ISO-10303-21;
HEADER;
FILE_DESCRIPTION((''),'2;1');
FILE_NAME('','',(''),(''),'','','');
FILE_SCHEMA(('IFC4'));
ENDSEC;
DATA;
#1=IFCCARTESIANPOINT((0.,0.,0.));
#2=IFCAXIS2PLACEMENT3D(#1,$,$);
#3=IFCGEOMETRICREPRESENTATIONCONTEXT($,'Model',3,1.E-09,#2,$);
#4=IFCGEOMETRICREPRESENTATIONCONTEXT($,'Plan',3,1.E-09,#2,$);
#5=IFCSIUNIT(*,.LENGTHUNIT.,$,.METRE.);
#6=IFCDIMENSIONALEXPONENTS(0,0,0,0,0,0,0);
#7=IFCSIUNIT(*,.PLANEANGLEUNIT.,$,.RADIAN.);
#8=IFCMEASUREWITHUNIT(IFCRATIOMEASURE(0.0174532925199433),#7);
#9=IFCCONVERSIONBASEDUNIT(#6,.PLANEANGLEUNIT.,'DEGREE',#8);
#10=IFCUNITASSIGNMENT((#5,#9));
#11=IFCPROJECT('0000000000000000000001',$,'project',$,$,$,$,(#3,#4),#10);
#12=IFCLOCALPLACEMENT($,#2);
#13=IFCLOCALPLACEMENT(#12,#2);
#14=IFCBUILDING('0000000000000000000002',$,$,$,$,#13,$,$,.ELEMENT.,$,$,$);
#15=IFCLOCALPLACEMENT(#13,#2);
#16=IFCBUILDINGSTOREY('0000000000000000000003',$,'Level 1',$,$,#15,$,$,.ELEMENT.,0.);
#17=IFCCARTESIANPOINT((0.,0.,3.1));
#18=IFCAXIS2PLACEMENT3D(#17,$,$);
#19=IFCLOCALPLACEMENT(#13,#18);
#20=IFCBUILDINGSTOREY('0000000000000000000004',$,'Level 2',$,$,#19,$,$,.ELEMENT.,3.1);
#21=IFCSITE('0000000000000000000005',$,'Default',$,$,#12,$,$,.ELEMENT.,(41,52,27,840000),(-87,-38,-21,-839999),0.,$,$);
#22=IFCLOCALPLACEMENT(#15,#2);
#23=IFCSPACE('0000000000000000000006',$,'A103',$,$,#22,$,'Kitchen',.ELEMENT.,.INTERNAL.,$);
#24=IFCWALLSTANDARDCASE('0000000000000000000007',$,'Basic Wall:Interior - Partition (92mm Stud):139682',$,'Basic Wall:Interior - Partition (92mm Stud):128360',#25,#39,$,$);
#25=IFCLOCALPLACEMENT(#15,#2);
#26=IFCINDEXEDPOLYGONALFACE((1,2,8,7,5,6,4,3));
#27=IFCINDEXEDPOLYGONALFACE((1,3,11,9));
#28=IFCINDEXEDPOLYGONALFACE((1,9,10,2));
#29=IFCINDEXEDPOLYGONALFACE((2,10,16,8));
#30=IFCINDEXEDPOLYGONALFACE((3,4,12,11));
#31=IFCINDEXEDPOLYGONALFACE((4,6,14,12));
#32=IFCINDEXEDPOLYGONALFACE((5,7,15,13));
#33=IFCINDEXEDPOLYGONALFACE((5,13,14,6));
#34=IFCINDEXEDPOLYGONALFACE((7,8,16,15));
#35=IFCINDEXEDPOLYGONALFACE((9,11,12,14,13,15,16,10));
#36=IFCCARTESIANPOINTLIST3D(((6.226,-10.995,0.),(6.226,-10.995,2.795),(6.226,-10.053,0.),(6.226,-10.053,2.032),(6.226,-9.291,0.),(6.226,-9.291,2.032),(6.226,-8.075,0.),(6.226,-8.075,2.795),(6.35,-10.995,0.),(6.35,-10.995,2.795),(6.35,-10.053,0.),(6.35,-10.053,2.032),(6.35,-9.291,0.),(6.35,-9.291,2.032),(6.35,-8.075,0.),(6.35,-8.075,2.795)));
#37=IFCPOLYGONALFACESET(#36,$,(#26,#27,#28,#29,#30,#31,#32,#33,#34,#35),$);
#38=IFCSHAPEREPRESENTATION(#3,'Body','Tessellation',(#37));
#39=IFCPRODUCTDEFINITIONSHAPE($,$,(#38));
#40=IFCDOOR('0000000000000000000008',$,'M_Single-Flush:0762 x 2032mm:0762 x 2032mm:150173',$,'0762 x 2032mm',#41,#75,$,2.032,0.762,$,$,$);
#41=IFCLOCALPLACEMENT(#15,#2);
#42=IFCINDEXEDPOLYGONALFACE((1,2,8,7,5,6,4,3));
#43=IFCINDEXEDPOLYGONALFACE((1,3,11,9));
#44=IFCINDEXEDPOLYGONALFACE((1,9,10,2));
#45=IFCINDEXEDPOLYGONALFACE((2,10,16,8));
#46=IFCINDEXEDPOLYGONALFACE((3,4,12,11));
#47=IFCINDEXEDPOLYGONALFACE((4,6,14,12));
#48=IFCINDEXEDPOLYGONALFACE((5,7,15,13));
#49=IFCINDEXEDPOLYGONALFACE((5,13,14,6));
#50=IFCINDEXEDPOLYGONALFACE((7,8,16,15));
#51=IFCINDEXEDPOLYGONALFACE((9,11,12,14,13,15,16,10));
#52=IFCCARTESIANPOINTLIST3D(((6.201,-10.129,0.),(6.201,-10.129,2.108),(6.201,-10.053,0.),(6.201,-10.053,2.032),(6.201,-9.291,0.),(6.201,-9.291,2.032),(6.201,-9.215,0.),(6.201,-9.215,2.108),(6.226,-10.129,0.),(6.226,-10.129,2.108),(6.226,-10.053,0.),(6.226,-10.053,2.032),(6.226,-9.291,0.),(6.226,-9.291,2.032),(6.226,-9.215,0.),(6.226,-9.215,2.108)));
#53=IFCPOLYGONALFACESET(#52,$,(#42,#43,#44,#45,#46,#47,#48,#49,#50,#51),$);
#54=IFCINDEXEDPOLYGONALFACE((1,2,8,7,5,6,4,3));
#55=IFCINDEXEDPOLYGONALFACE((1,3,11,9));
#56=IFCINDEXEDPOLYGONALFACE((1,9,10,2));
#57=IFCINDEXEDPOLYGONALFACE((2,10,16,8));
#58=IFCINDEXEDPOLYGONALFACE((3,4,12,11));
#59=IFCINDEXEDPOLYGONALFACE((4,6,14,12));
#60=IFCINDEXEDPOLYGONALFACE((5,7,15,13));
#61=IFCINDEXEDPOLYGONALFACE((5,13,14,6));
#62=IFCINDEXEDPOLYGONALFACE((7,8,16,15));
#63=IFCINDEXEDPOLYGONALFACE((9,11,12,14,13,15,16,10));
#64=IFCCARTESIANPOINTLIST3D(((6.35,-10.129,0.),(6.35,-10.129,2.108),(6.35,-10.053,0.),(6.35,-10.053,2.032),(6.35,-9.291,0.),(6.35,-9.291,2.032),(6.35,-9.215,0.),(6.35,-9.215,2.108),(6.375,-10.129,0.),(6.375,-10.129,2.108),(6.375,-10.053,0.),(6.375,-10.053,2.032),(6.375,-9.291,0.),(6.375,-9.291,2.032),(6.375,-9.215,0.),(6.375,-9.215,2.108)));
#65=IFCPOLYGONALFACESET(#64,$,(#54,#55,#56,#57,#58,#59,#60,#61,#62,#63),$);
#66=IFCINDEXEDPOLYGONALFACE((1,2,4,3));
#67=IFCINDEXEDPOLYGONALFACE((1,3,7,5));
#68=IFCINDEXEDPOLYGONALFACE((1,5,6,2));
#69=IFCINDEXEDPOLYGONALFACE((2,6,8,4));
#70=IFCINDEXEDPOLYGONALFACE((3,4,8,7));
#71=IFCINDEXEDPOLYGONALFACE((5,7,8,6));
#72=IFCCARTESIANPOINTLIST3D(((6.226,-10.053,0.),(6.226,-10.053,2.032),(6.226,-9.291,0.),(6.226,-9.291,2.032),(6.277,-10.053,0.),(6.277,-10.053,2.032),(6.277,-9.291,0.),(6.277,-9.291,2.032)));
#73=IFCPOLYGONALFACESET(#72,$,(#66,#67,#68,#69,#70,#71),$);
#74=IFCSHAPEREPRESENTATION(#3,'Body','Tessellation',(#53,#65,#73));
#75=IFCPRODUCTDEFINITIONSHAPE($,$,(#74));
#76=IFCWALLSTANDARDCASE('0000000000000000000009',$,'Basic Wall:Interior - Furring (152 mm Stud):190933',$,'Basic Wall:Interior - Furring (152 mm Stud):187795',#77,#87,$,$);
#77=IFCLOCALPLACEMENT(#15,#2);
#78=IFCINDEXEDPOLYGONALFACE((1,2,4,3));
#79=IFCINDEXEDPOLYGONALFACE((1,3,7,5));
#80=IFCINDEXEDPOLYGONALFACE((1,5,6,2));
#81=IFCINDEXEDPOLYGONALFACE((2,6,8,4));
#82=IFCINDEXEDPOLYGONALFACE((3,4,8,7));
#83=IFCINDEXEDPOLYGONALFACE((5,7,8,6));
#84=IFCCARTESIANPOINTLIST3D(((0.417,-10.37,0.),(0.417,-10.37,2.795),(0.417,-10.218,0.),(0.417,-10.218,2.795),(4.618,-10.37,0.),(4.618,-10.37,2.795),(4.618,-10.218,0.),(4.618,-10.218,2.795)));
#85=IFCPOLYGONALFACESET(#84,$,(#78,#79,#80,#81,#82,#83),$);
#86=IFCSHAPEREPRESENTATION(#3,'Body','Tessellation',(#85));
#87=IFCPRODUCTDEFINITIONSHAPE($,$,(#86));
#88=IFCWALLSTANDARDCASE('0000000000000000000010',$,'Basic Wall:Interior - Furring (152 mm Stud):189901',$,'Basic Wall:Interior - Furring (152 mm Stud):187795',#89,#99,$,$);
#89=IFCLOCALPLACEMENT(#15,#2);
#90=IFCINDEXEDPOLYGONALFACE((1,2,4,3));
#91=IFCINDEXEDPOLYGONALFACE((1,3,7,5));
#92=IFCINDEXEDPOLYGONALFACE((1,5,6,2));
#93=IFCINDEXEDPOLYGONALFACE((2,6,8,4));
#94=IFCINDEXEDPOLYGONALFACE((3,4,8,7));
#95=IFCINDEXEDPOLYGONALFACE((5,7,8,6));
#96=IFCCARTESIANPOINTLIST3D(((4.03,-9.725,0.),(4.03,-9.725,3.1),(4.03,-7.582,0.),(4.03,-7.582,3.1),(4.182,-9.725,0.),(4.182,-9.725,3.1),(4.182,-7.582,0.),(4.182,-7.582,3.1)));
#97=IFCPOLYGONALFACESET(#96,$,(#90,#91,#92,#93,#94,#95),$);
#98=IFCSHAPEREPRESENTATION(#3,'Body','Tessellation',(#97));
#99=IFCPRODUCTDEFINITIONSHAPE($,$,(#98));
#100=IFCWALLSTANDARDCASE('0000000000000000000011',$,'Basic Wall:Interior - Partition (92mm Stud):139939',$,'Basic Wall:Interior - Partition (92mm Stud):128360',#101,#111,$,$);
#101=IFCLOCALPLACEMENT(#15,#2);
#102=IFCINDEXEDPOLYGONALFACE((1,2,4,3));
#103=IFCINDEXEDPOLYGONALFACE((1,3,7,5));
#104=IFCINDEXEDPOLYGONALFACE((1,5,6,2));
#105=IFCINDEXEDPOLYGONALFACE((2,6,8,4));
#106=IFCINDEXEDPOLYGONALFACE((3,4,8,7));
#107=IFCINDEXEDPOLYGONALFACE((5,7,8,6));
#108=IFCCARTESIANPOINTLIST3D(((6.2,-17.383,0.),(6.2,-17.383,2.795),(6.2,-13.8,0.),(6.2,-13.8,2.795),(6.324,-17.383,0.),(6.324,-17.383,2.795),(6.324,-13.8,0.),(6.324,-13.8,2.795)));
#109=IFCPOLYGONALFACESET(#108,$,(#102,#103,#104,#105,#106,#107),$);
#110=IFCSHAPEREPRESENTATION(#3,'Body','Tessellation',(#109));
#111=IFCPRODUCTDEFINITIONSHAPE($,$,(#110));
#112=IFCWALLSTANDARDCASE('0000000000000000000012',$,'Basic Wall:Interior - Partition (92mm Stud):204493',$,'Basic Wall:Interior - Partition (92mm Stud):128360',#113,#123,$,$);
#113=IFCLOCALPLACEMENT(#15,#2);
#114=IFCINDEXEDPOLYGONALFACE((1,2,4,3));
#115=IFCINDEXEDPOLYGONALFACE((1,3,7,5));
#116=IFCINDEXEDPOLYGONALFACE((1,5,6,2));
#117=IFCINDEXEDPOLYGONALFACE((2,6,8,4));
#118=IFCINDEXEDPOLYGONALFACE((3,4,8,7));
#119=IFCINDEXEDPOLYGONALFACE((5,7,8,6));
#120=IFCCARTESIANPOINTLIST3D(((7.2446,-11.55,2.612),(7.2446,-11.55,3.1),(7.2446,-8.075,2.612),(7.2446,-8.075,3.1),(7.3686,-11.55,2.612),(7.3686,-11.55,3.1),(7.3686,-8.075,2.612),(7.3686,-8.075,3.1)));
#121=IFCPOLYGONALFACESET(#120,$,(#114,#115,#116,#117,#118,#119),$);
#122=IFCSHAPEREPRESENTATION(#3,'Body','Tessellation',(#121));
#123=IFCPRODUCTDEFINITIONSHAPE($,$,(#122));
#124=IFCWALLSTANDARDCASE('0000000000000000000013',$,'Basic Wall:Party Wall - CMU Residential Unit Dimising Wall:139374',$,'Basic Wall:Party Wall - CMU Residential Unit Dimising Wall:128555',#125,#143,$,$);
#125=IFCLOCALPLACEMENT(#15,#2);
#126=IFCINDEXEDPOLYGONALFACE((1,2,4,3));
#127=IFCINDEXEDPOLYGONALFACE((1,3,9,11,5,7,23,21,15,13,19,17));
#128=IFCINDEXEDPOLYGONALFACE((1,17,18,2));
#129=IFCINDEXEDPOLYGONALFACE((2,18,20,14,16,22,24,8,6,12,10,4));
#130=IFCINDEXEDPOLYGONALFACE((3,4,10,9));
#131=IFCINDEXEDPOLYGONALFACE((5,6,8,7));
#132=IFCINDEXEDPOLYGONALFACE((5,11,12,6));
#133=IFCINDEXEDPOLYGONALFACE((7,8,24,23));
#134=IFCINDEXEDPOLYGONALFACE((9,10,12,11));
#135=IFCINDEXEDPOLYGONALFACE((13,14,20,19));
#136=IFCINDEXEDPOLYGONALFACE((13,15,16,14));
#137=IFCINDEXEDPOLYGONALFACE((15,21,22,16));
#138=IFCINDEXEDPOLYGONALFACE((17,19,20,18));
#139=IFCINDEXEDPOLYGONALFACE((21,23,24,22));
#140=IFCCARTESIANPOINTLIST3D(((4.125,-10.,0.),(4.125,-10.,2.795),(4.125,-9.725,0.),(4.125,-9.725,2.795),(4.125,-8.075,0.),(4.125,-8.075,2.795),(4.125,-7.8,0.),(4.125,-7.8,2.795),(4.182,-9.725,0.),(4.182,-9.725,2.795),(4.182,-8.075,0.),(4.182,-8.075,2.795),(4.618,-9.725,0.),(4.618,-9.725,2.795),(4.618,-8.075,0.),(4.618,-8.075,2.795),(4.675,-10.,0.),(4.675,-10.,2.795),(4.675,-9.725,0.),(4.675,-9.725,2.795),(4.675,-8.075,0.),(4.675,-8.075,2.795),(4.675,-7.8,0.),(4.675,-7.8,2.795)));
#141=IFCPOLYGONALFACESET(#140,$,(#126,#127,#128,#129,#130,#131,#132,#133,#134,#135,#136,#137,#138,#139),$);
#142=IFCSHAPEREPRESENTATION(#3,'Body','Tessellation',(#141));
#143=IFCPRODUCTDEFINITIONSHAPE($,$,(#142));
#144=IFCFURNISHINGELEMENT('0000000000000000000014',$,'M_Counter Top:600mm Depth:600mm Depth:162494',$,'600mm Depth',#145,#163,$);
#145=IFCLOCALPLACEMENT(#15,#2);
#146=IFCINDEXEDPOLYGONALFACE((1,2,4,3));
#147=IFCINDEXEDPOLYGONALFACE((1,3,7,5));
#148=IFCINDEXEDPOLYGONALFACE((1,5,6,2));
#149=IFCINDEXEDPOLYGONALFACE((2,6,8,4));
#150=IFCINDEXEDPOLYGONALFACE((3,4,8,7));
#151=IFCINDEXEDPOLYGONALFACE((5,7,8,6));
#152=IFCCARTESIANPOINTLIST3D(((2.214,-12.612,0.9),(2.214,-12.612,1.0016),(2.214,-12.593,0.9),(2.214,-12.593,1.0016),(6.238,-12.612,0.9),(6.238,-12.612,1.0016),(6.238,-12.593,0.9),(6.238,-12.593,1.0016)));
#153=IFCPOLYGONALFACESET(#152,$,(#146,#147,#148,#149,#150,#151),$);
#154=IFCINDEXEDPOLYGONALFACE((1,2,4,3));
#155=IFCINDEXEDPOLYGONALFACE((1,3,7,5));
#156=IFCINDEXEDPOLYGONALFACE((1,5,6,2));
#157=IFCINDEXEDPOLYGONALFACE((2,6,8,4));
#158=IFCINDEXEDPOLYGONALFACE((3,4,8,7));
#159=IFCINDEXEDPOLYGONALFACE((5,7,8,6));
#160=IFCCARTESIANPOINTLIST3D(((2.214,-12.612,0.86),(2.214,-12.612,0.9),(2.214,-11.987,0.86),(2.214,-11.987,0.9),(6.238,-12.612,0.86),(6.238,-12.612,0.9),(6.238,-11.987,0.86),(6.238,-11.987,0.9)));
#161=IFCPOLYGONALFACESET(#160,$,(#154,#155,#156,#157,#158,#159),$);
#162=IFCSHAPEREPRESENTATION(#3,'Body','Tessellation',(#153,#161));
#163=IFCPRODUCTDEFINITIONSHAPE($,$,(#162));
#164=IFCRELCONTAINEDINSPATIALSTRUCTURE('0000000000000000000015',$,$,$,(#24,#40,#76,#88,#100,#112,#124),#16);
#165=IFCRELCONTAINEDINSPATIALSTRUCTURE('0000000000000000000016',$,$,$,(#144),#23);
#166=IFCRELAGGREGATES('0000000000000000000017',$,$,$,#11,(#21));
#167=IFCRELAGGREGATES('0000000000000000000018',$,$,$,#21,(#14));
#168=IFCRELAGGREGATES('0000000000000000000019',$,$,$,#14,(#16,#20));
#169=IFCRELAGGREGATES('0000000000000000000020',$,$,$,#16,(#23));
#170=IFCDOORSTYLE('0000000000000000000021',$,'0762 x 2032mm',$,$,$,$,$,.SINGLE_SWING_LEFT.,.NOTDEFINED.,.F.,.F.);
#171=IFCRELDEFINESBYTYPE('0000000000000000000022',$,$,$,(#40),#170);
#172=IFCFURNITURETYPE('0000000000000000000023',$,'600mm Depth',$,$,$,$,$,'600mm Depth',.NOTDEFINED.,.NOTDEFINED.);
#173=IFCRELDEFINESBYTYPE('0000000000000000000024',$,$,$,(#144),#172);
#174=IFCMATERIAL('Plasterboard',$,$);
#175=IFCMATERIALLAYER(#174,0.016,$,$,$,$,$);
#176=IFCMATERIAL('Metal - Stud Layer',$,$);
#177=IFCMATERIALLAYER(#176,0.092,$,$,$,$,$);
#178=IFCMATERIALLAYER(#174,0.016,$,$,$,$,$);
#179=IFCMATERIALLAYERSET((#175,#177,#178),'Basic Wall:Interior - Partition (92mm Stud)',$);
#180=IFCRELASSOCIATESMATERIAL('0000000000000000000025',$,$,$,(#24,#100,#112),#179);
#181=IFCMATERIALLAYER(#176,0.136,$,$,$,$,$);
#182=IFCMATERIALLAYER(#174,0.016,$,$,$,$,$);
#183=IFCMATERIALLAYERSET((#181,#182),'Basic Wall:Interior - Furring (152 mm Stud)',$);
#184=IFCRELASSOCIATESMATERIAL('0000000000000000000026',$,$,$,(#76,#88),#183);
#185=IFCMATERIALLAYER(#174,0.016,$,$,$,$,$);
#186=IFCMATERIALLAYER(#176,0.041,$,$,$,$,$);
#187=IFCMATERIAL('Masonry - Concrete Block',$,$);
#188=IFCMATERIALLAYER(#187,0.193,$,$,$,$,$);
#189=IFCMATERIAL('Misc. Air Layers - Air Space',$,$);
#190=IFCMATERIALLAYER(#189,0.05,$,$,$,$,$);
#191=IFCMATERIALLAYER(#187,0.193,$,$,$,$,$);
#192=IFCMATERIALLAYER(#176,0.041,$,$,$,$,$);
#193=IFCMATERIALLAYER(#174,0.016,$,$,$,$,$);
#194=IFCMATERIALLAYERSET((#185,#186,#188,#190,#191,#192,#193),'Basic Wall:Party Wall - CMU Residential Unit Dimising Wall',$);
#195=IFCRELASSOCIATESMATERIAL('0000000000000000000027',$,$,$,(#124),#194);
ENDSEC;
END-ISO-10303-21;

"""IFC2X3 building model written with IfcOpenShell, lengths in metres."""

from ifc_helpers import new_model, entity, si_unit, converted_unit, frame, frame_2d, origin, origin_2d_with_axis, place, context, project, spatial, polyline, rectangle, outline, extrude, clip, bounded_halfspace, source, transform, mapped, material, layer, layer_set, layer_usage, type_object, type_shapes, element, fill, save


model = new_model("IFC2X3")

# Units and contexts
model_context = context("Model", 3, precision=1e-09, world=origin())
plan_context = context("Plan", 3, precision=1e-09, world=origin())
ifc_project = project(units=[si_unit("LENGTHUNIT", "METRE"), converted_unit("PLANEANGLEUNIT", "DEGREE", entity("IfcRatioMeasure", 0.0174532925199433), si_unit("PLANEANGLEUNIT", "RADIAN"), dimensions=[0, 0, 0, 0, 0, 0, 0])], contexts=[model_context, plan_context])

# Site, building, storey
site_placement = place(None, origin())
site = spatial("IfcSite", under=ifc_project, at=site_placement, Name="Default", CompositionType="ELEMENT", RefLatitude=(41, 52, 27, 840000), RefLongitude=(-87, -38, -21, -839999), RefElevation=0.0)
building_placement = place(site_placement, origin())
building = spatial("IfcBuilding", under=site, at=building_placement, CompositionType="ELEMENT")
storey_1_placement = place(building_placement, origin())
storey_1 = spatial("IfcBuildingStorey", under=building, at=storey_1_placement, Name="Level 1", CompositionType="ELEMENT", Elevation=0.0)

# Shared definitions
ifc_material_1 = material(Name="Misc. Air Layers - Air Space")
ifc_material_2 = material(Name="Masonry - Concrete Block")
ifc_material_3 = material(Name="Metal - Stud Layer")
ifc_material_4 = material(Name="Plasterboard")

# Shared definitions
ifc_layer_1 = layer(ifc_material_4, 0.016)
ifc_layer_2 = layer(ifc_material_3, 0.041)
ifc_layer_3 = layer(ifc_material_2, 0.193)
ifc_layer_4 = layer(ifc_material_1, 0.05)
ifc_layer_5 = layer(ifc_material_2, 0.193)
ifc_layer_6 = layer(ifc_material_3, 0.041)
ifc_layer_7 = layer(ifc_material_4, 0.016)
ifc_layer_set_1 = layer_set([ifc_layer_1, ifc_layer_2, ifc_layer_3, ifc_layer_4, ifc_layer_5, ifc_layer_6, ifc_layer_7], Name="Basic Wall:Party Wall - CMU Residential Unit Dimising Wall")
ifc_layer_usage_1 = layer_usage(ifc_layer_set_1, "AXIS2", "NEGATIVE", 0.275)
ifc_layer_8 = layer(ifc_material_4, 0.016)
ifc_layer_9 = layer(ifc_material_3, 0.092)
ifc_layer_10 = layer(ifc_material_4, 0.016)
ifc_layer_set_2 = layer_set([ifc_layer_8, ifc_layer_9, ifc_layer_10], Name="Basic Wall:Interior - Partition (92mm Stud)")
ifc_layer_usage_2 = layer_usage(ifc_layer_set_2, "AXIS2", "NEGATIVE", 0.062)

# Shared definitions
storey_2_placement = place(building_placement, frame((0.0, 0.0, 3.1)))
storey_2 = spatial("IfcBuildingStorey", under=building, at=storey_2_placement, Name="Level 2", CompositionType="ELEMENT", Elevation=3.1)

# Wall, opening, door
wall_1_placement = place(storey_1_placement, frame((6.288, -10.995, 0.0), z_axis=(0.0, 0.0, 1.0), x_axis=(0.0, 1.0, 0.0)))
wall_1 = element("IfcWallStandardCase", 1, at=wall_1_placement, inside=storey_1, material=ifc_layer_usage_2, Name="Basic Wall:Interior - Partition (92mm Stud):139682", ObjectType="Basic Wall:Interior - Partition (92mm Stud):128360", context=model_context, shape_type="SweptSolid", body=[
    extrude(rectangle(XDim=2.92, YDim=0.124, at=frame_2d((1.46, 0.0), x_axis=(-1.0, 0.0))), origin(), (0.0, 0.0, 1.0), 2.795),
])
opening_1_placement = place(wall_1_placement, frame((0.942, -0.062, 0.0)))
opening_1 = element("IfcOpeningElement", 2, at=opening_1_placement, cuts=wall_1, ObjectType="Opening", context=model_context, shape_type="SweptSolid", body=[
    extrude(rectangle(XDim=0.762, YDim=2.032, at=frame_2d((1.016, 0.381), x_axis=(0.0, -1.0))), frame((0.0, 0.0, 0.0), z_axis=(0.0, 1.0, 0.0), x_axis=(0.0, 0.0, 1.0)), (0.0, 0.0, 1.0), 0.124),
])
door_style_1 = type_object("IfcDoorStyle", Name="0762 x 2032mm", ConstructionType="NOTDEFINED", OperationType="SINGLE_SWING_LEFT", ParameterTakesPrecedence=False, Sizeable=False)
shared_shape_1 = source(origin(), model_context, "Body", "SweptSolid", [
    extrude(outline(polyline([(-0.457, -1.073), (0.457, -1.073), (0.457, 1.035), (0.381, 1.035), (0.381, -0.997), (-0.381, -0.997), (-0.381, 1.035), (-0.457, 1.035), (-0.457, -1.073)])), frame((0.381, 0.149, 1.035), z_axis=(0.0, -1.0, 0.0), x_axis=(-1.0, 0.0, 0.0)), (0.0, 0.0, 1.0), 0.025),
    extrude(outline(polyline([(-1.073, -0.457), (1.035, -0.457), (1.035, -0.381), (-0.997, -0.381), (-0.997, 0.381), (1.035, 0.381), (1.035, 0.457), (-1.073, 0.457), (-1.073, -0.457)])), frame((0.381, 0.0, 1.035), z_axis=(0.0, -1.0, 0.0), x_axis=(0.0, 0.0, -1.0)), (0.0, 0.0, 1.0), 0.025),
    extrude(rectangle(XDim=0.762, YDim=0.051, at=origin_2d_with_axis()), frame((0.381, 0.0985, 0.0)), (0.0, 0.0, 1.0), 2.032),
])
type_shapes(door_style_1, [shared_shape_1])
door_1_placement = place(opening_1_placement, origin())
door_1 = element("IfcDoor", 3, at=door_1_placement, inside=storey_1, type_object=door_style_1, Name="M_Single-Flush:0762 x 2032mm:0762 x 2032mm:150173", ObjectType="0762 x 2032mm", OverallHeight=2.032, OverallWidth=0.762, context=model_context, shape_type="MappedRepresentation", body=[
    mapped(shared_shape_1, transform((0.0, 0.0, 0.0), scale=1.0)),
])
fill(opening_1, door_1)

# Walls
ifc_layer_11 = layer(ifc_material_3, 0.136)
ifc_layer_12 = layer(ifc_material_4, 0.016)
ifc_layer_set_3 = layer_set([ifc_layer_11, ifc_layer_12], Name="Basic Wall:Interior - Furring (152 mm Stud)")
ifc_layer_usage_3 = layer_usage(ifc_layer_set_3, "AXIS2", "NEGATIVE", 0.076)
wall_2_placement = place(storey_1_placement, frame((0.417, -10.294, 0.0)))
element("IfcWallStandardCase", 4, at=wall_2_placement, inside=storey_1, material=ifc_layer_usage_3, Name="Basic Wall:Interior - Furring (152 mm Stud):190933", ObjectType="Basic Wall:Interior - Furring (152 mm Stud):187795", context=model_context, shape_type="SweptSolid", body=[
    extrude(rectangle(XDim=4.201, YDim=0.152, at=frame_2d((2.1005, 0.0), x_axis=(-1.0, 0.0))), origin(), (0.0, 0.0, 1.0), 2.795),
])
ifc_layer_usage_4 = layer_usage(ifc_layer_set_3, "AXIS2", "POSITIVE", -0.076)
wall_3_placement = place(storey_1_placement, frame((4.106, -9.725, 0.0), z_axis=(0.0, 0.0, 1.0), x_axis=(0.0, 1.0, 0.0)))
element("IfcWallStandardCase", 5, at=wall_3_placement, inside=storey_1, material=ifc_layer_usage_4, Name="Basic Wall:Interior - Furring (152 mm Stud):189901", ObjectType="Basic Wall:Interior - Furring (152 mm Stud):187795", context=model_context, shape_type="SweptSolid", body=[
    extrude(rectangle(XDim=2.143, YDim=0.152, at=frame_2d((1.0715, 0.0), x_axis=(-1.0, 0.0))), origin(), (0.0, 0.0, 1.0), 3.1),
])
wall_4_placement = place(storey_1_placement, frame((6.262, -13.8, 0.0), z_axis=(0.0, 0.0, 1.0), x_axis=(0.0, -1.0, 0.0)))
element("IfcWallStandardCase", 6, at=wall_4_placement, inside=storey_1, material=ifc_layer_usage_2, Name="Basic Wall:Interior - Partition (92mm Stud):139939", ObjectType="Basic Wall:Interior - Partition (92mm Stud):128360", context=model_context, shape_type="SweptSolid", body=[
    extrude(rectangle(XDim=3.583, YDim=0.124, at=frame_2d((1.7915, 0.0), x_axis=(-1.0, 0.0))), origin(), (0.0, 0.0, 1.0), 2.795),
])
wall_5_placement = place(storey_1_placement, frame((7.3066, -11.55, 2.612), z_axis=(0.0, 0.0, 1.0), x_axis=(0.0, 1.0, 0.0)))
element("IfcWallStandardCase", 7, at=wall_5_placement, inside=storey_1, material=ifc_layer_usage_2, Name="Basic Wall:Interior - Partition (92mm Stud):204493", ObjectType="Basic Wall:Interior - Partition (92mm Stud):128360", context=model_context, shape_type="SweptSolid", body=[
    extrude(rectangle(XDim=3.475, YDim=0.124, at=frame_2d((1.7375, 0.0), x_axis=(-1.0, 0.0))), origin(), (0.0, 0.0, 1.0), 0.488),
])
wall_6_placement = place(storey_1_placement, frame((4.4, -10.0, 0.0), z_axis=(0.0, 0.0, 1.0), x_axis=(0.0, 1.0, 0.0)))
element("IfcWallStandardCase", 8, at=wall_6_placement, inside=storey_1, material=ifc_layer_usage_1, Name="Basic Wall:Party Wall - CMU Residential Unit Dimising Wall:139374", ObjectType="Basic Wall:Party Wall - CMU Residential Unit Dimising Wall:128555", context=model_context, shape_type="Clipping", body=[
    clip(clip(extrude(rectangle(XDim=2.2, YDim=0.55, at=frame_2d((1.1, 0.0), x_axis=(-1.0, 0.0))), origin(), (0.0, 0.0, 1.0), 2.795), bounded_halfspace(frame((1.925, 0.218, 0.0), z_axis=(0.0, -1.0, 0.0), x_axis=(1.0, 0.0, 0.0)), True, frame((1.925, 0.218, 0.0), z_axis=(0.0, -1.0, 0.0), x_axis=(1.0, 0.0, 0.0)), polyline([(0.0, 0.0), (0.0, 2.795), (-1.65, 2.795), (-1.65, 0.0), (0.0, 0.0)]))), bounded_halfspace(frame((0.275, -0.218, 0.0), z_axis=(0.0, 1.0, 0.0), x_axis=(-1.0, 0.0, 0.0)), True, frame((0.275, -0.218, 0.0), z_axis=(0.0, 1.0, 0.0), x_axis=(-1.0, 0.0, 0.0)), polyline([(0.0, 0.0), (0.0, 2.795), (-1.65, 2.795), (-1.65, 0.0), (0.0, 0.0)]))),
])

# Shared definitions
space_1_placement = place(storey_1_placement, origin())
space_1 = spatial("IfcSpace", under=storey_1, at=space_1_placement, Name="A103", LongName="Kitchen", CompositionType="ELEMENT", InteriorOrExteriorSpace="INTERNAL")

# Furnishing element
furniture_type_1 = type_object("IfcFurnitureType", Name="600mm Depth", ElementType="600mm Depth", AssemblyPlace="NOTDEFINED")
shared_shape_2 = source(origin(), model_context, "Body", "SweptSolid", [
    extrude(rectangle(XDim=0.0191, YDim=4.024, at=origin_2d_with_axis()), frame((0.8115, -0.0095, 0.9), z_axis=(0.0, 0.0, 1.0), x_axis=(0.0, -1.0, 0.0)), (0.0, 0.0, 1.0), 0.1016),
    extrude(rectangle(XDim=4.024, YDim=0.625, at=origin_2d_with_axis()), frame((0.8115, -0.3125, 0.86), z_axis=(0.0, 0.0, 1.0), x_axis=(-1.0, 0.0, 0.0)), (0.0, 0.0, 1.0), 0.04),
])
type_shapes(furniture_type_1, [shared_shape_2])
furnishing_1_placement = place(space_1_placement, frame((5.0375, -12.612, 0.0), z_axis=(0.0, 0.0, 1.0), x_axis=(-1.0, 0.0, 0.0)))
element("IfcFurnishingElement", 9, at=furnishing_1_placement, inside=space_1, type_object=furniture_type_1, Name="M_Counter Top:600mm Depth:600mm Depth:162494", ObjectType="600mm Depth", context=model_context, shape_type="MappedRepresentation", body=[
    mapped(shared_shape_2, transform((0.0, 0.0, 0.0), scale=1.0)),
])

save(model, "model.ifc")
